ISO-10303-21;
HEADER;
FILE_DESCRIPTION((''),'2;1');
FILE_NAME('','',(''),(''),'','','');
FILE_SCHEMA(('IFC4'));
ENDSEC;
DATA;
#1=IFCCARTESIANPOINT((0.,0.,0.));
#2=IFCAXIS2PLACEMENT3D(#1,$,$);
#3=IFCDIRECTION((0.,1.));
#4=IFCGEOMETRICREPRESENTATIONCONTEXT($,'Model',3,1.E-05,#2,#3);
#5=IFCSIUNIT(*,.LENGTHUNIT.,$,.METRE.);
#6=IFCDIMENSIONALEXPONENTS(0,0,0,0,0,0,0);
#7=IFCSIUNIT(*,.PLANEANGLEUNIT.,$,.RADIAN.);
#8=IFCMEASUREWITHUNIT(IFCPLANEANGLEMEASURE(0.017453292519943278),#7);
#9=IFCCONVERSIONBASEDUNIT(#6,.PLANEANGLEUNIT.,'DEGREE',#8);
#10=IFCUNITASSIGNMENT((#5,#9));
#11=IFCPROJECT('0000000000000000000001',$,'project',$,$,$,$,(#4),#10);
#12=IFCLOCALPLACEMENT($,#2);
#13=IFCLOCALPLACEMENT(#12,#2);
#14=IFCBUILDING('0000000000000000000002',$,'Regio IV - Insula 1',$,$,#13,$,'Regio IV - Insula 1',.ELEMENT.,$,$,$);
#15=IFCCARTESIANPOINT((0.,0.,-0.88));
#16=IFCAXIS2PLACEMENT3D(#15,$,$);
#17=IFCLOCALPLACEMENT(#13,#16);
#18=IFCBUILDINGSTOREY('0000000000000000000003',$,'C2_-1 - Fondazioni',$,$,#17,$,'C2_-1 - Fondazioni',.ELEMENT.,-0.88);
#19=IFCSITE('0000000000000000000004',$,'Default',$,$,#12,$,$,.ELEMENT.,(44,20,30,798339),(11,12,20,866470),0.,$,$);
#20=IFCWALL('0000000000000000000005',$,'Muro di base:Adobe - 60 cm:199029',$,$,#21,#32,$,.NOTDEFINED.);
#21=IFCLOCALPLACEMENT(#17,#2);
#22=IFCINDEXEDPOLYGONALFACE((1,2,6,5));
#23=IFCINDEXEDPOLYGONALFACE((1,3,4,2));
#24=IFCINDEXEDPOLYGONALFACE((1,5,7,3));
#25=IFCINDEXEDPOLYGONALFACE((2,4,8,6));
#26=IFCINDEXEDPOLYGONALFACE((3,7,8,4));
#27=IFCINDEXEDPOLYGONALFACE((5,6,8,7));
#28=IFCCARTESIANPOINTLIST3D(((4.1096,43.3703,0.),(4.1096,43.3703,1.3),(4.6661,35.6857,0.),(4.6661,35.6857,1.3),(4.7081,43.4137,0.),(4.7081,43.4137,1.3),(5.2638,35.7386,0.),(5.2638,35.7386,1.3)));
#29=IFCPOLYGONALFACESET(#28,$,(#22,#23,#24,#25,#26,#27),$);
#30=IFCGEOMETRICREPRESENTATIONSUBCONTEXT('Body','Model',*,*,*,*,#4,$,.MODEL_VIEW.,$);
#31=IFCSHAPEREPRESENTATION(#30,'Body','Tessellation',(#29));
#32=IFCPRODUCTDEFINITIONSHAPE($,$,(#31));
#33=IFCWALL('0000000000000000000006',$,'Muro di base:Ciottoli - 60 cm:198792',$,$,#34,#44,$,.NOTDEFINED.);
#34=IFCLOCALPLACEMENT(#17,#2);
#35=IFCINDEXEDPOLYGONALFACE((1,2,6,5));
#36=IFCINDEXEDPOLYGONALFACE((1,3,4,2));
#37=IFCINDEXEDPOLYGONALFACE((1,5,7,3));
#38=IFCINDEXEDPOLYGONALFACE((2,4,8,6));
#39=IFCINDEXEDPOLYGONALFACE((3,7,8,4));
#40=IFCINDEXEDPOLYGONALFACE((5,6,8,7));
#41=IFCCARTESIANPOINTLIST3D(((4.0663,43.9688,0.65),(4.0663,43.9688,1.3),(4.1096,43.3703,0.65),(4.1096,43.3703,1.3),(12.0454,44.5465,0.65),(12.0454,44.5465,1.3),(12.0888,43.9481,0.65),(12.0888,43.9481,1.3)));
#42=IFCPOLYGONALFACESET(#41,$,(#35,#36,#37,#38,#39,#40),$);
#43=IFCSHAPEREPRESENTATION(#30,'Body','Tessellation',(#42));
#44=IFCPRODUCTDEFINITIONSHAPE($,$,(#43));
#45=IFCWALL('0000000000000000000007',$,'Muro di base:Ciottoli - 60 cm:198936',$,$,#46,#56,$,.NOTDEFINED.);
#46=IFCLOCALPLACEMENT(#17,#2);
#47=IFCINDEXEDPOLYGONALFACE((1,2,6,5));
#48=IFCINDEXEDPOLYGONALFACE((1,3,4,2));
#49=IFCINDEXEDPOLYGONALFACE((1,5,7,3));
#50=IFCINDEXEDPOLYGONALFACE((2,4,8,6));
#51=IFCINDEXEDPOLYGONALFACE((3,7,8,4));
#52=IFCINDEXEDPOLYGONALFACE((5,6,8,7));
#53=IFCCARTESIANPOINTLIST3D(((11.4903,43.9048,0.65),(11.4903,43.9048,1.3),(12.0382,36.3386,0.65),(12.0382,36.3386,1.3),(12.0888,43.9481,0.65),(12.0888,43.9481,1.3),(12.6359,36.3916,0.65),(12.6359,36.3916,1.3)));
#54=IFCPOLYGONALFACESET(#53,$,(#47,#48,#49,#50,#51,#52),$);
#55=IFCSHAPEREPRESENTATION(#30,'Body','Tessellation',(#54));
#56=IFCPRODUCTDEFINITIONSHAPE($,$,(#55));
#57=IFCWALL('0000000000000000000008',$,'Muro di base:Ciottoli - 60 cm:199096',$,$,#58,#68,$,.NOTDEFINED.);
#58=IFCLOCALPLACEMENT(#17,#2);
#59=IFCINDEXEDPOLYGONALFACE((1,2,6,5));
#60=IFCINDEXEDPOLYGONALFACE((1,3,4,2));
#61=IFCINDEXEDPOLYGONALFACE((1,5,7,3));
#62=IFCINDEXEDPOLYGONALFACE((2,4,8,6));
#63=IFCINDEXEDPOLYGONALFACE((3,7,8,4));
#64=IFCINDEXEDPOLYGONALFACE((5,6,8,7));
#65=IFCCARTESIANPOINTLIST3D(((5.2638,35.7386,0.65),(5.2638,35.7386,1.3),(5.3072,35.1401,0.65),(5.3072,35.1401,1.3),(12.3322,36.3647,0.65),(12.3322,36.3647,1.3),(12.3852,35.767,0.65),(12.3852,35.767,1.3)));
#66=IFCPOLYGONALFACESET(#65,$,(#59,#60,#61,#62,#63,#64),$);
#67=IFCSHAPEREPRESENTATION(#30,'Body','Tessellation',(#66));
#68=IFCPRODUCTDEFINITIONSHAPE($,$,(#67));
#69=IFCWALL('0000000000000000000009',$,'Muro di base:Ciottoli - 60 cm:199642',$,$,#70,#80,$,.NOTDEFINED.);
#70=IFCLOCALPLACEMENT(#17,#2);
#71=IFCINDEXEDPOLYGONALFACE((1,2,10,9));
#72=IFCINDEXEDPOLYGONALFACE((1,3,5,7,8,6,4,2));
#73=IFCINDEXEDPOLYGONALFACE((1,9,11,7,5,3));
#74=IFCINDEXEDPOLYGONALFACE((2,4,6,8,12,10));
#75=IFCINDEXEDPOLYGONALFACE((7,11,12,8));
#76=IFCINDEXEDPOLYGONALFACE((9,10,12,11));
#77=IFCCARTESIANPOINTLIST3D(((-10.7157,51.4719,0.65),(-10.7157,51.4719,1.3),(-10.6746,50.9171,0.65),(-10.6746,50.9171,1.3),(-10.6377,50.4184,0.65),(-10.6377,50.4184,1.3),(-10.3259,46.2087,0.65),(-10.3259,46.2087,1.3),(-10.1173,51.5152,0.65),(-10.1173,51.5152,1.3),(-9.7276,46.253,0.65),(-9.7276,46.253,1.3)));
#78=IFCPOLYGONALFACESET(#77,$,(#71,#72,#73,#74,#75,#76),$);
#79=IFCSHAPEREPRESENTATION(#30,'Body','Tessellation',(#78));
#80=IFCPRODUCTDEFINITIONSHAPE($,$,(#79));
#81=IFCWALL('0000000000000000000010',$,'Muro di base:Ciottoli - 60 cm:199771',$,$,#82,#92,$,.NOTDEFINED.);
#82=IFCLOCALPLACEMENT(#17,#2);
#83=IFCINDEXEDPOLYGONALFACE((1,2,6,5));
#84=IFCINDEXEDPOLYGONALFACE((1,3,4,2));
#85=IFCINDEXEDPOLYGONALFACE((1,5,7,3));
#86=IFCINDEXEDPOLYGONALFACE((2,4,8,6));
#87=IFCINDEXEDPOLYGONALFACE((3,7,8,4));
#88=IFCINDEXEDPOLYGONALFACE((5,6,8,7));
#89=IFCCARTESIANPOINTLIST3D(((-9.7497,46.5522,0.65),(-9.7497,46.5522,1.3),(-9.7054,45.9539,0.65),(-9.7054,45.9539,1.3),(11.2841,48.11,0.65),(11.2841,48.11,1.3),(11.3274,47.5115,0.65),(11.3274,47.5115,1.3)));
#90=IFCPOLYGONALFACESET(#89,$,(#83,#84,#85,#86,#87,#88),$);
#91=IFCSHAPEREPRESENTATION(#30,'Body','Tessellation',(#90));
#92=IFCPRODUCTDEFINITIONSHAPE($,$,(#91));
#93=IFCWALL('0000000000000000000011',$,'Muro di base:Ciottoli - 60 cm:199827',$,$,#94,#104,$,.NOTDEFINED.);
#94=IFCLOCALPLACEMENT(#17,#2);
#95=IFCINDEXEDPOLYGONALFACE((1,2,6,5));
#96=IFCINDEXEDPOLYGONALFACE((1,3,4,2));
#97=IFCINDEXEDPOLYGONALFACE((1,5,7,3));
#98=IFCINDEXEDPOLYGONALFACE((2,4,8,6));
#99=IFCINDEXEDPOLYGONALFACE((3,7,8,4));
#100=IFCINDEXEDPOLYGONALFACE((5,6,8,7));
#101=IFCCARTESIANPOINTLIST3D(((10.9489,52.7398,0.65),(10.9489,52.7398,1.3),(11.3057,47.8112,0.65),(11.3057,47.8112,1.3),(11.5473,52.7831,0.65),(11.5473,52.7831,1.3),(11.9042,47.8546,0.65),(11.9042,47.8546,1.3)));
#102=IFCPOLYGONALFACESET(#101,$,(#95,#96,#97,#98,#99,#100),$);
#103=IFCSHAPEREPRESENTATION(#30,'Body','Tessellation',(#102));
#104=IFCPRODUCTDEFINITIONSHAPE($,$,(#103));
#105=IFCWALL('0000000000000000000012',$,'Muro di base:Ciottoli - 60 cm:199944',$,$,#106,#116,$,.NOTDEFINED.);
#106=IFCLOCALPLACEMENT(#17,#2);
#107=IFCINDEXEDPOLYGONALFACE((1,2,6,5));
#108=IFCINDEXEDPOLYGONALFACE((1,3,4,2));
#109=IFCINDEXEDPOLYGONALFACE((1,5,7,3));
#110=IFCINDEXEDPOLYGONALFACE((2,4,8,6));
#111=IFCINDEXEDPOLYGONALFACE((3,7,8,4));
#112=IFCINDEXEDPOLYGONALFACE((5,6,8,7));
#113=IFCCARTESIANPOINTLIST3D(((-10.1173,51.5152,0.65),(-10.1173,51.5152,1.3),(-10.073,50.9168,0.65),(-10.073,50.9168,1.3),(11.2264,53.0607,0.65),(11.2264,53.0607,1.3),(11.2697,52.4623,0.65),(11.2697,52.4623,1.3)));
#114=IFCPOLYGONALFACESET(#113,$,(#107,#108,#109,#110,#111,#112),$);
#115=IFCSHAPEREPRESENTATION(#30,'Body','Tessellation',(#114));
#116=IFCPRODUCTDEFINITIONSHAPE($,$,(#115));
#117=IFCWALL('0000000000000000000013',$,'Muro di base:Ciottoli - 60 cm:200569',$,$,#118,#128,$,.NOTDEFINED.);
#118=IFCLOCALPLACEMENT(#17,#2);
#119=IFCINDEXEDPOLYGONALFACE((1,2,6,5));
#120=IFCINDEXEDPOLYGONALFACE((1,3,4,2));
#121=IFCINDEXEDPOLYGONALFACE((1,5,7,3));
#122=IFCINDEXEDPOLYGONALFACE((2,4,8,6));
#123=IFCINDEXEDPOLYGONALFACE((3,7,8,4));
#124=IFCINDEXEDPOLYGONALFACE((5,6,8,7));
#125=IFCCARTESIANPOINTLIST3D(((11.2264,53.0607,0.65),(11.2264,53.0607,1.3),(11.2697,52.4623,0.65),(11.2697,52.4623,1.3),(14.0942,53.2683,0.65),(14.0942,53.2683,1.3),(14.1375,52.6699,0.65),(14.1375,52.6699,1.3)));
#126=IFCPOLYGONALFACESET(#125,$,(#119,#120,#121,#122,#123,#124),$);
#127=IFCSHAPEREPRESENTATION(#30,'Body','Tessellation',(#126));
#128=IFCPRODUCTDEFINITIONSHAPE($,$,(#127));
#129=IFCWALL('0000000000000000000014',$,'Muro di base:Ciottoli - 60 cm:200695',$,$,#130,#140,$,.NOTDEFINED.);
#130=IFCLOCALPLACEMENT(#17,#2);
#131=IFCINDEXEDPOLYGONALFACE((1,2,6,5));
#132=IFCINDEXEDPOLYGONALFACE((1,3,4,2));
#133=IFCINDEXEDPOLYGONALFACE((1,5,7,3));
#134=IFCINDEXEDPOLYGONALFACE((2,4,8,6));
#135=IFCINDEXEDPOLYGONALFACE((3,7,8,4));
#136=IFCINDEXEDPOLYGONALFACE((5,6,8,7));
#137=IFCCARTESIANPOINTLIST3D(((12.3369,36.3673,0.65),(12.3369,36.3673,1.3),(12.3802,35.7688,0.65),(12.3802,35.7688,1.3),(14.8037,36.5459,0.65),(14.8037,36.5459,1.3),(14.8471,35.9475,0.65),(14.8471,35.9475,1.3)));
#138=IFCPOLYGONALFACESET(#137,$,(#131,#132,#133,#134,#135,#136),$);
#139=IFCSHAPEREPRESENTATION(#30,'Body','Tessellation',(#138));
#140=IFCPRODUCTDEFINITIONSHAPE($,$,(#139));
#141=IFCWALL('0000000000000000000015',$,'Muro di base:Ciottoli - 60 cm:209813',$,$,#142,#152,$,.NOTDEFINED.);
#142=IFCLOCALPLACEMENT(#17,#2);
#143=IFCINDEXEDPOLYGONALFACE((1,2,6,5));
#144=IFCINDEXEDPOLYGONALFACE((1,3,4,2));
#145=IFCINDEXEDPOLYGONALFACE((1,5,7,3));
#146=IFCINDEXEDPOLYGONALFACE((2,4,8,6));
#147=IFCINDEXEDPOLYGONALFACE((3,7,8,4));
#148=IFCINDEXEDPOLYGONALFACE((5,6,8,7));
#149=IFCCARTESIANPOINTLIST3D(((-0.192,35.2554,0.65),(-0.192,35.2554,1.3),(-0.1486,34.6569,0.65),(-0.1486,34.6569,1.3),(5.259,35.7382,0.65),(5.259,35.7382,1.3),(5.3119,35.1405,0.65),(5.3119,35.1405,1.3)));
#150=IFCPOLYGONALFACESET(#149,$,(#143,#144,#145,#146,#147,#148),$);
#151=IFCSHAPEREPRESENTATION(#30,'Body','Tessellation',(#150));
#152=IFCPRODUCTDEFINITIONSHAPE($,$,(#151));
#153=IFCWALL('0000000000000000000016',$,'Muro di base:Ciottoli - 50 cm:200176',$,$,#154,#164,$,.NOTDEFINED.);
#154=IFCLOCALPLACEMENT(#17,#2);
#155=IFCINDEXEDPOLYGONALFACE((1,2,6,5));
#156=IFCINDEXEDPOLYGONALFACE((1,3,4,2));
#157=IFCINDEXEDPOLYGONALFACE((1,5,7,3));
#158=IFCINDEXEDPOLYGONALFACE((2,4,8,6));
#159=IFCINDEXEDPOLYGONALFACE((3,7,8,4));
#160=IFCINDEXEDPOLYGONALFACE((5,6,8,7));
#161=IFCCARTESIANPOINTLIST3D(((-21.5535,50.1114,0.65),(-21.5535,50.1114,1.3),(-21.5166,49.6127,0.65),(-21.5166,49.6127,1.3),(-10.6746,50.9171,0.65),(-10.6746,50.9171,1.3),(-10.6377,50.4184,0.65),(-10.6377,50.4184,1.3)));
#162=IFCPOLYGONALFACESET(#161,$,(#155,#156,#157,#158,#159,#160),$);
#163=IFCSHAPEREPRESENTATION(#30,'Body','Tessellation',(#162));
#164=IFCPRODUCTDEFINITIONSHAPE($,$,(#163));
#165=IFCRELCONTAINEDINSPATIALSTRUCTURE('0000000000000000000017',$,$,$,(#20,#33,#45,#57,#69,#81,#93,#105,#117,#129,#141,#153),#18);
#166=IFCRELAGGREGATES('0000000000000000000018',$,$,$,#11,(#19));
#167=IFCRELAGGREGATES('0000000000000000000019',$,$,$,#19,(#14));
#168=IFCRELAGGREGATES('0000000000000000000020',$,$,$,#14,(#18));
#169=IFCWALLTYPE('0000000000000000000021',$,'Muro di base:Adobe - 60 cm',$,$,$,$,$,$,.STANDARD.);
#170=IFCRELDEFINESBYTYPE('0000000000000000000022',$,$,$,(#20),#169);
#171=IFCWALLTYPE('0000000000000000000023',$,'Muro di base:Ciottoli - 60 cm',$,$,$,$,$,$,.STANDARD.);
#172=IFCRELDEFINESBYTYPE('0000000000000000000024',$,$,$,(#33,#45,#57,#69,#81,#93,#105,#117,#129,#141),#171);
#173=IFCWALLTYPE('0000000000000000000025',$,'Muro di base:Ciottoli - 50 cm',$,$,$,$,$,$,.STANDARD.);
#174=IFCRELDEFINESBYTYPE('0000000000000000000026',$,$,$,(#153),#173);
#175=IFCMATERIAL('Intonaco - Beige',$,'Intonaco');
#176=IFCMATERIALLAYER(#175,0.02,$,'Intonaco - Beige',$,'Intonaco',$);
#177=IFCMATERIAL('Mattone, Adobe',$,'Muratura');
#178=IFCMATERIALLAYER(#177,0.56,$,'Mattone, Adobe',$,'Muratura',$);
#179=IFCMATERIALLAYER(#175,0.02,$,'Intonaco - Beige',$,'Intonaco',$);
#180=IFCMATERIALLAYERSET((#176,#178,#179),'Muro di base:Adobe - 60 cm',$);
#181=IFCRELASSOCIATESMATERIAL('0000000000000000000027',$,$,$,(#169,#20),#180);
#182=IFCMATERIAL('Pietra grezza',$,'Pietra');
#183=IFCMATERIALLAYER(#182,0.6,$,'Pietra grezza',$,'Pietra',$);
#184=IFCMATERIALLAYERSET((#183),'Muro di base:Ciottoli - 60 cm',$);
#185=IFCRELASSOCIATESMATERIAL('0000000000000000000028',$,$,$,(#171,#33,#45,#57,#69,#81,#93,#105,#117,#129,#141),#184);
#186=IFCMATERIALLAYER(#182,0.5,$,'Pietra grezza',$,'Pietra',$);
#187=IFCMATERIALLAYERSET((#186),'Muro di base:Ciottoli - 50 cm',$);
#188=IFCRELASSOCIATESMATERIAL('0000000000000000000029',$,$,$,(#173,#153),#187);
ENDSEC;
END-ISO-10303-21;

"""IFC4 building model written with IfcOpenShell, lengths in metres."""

from ifc_helpers import new_model, entity, si_unit, converted_unit, direction, frame, frame_2d, origin, place, context, subcontext, project, spatial, polyline, rectangle, outline, extrude, material, layer, layer_set, layer_usage, type_object, element, save


model = new_model("IFC4")

# Units and contexts
model_context = context("Model", 3, precision=1e-05, world=origin(), true_north=direction((0.0, 1.0)))
body_context = subcontext(model_context, "Body", "Model", "MODEL_VIEW")
ifc_project = project(units=[si_unit("LENGTHUNIT", "METRE"), converted_unit("PLANEANGLEUNIT", "DEGREE", entity("IfcPlaneAngleMeasure", 0.017453292519943278), si_unit("PLANEANGLEUNIT", "RADIAN"), dimensions=[0, 0, 0, 0, 0, 0, 0])], contexts=[model_context])

# Site, building, storey
site_placement = place(None, origin())
site = spatial("IfcSite", under=ifc_project, at=site_placement, Name="Default", CompositionType="ELEMENT", RefLatitude=(44, 20, 30, 798339), RefLongitude=(11, 12, 20, 866470), RefElevation=0.0)
building_placement = place(site_placement, origin())
building = spatial("IfcBuilding", under=site, at=building_placement, Name="Regio IV - Insula 1", LongName="Regio IV - Insula 1", CompositionType="ELEMENT")
storey_placement = place(building_placement, frame((0.0, 0.0, -0.88)))
storey = spatial("IfcBuildingStorey", under=building, at=storey_placement, Name="C2_-1 - Fondazioni", LongName="C2_-1 - Fondazioni", CompositionType="ELEMENT", Elevation=-0.88)

# Walls
ifc_material_1 = material(Name="Intonaco - Beige", Category="Intonaco")
ifc_layer_1 = layer(ifc_material_1, 0.02, Name="Intonaco - Beige", Category="Intonaco")
ifc_material_2 = material(Name="Mattone, Adobe", Category="Muratura")
ifc_layer_2 = layer(ifc_material_2, 0.56, Name="Mattone, Adobe", Category="Muratura")
ifc_layer_3 = layer(ifc_material_1, 0.02, Name="Intonaco - Beige", Category="Intonaco")
ifc_layer_set_1 = layer_set([ifc_layer_1, ifc_layer_2, ifc_layer_3], Name="Muro di base:Adobe - 60 cm")
ifc_layer_usage_1 = layer_usage(ifc_layer_set_1, "AXIS2", "NEGATIVE", 0.3)
wall_type_1 = type_object("IfcWallType", Name="Muro di base:Adobe - 60 cm", PredefinedType="STANDARD", material=ifc_layer_set_1)
wall_1_placement = place(storey_placement, frame((4.4089, 43.392, 0.0), z_axis=(0.0, 0.0, 1.0), x_axis=(0.07222, -0.997389, 0.0)))
element("IfcWall", 1, at=wall_1_placement, inside=storey, type_object=wall_type_1, material=ifc_layer_usage_1, Name="Muro di base:Adobe - 60 cm:199029", PredefinedType="NOTDEFINED", context=body_context, shape_type="SweptSolid", body=[
    extrude(outline(polyline([(7.7048, -0.3), (7.6951, 0.3), (0.0, 0.3), (0.0, -0.3), (7.7048, -0.3)])), origin(), (0.0, 0.0, 1.0), 1.3),
])
ifc_material_3 = material(Name="Pietra grezza", Category="Pietra")
ifc_layer_4 = layer(ifc_material_3, 0.6, Name="Pietra grezza", Category="Pietra")
ifc_layer_set_2 = layer_set([ifc_layer_4], Name="Muro di base:Ciottoli - 60 cm")
ifc_layer_usage_2 = layer_usage(ifc_layer_set_2, "AXIS2", "NEGATIVE", 0.3)
wall_type_2 = type_object("IfcWallType", Name="Muro di base:Ciottoli - 60 cm", PredefinedType="STANDARD", material=ifc_layer_set_2)
wall_2_placement = place(storey_placement, frame((4.088, 43.6695, 0.65), z_axis=(0.0, 0.0, 1.0), x_axis=(0.997389, 0.07222, 0.0)))
element("IfcWall", 2, at=wall_2_placement, inside=storey, type_object=wall_type_2, material=ifc_layer_usage_2, Name="Muro di base:Ciottoli - 60 cm:198792", PredefinedType="NOTDEFINED", context=body_context, shape_type="SweptSolid", body=[
    extrude(rectangle(XDim=8.0, YDim=0.6, at=frame_2d((4.0, 0.0), x_axis=(-1.0, 0.0))), origin(), (0.0, 0.0, 1.0), 0.65),
])
ifc_layer_usage_3 = layer_usage(ifc_layer_set_2, "AXIS2", "NEGATIVE", 0.3)
wall_3_placement = place(storey_placement, frame((11.7895, 43.9264, 0.65), z_axis=(0.0, 0.0, 1.0), x_axis=(0.07222, -0.997389, 0.0)))
element("IfcWall", 3, at=wall_3_placement, inside=storey, type_object=wall_type_2, material=ifc_layer_usage_3, Name="Muro di base:Ciottoli - 60 cm:198936", PredefinedType="NOTDEFINED", context=body_context, shape_type="SweptSolid", body=[
    extrude(outline(polyline([(7.5859, -0.3), (7.5763, 0.3), (0.0, 0.3), (0.0, -0.3), (7.5859, -0.3)])), origin(), (0.0, 0.0, 1.0), 0.65),
])
ifc_layer_usage_4 = layer_usage(ifc_layer_set_2, "AXIS2", "NEGATIVE", 0.3)
wall_4_placement = place(storey_placement, frame((5.2807, 35.4389, 0.65), z_axis=(0.0, 0.0, 1.0), x_axis=(0.996101, 0.088225, 0.0)))
element("IfcWall", 4, at=wall_4_placement, inside=storey, type_object=wall_type_2, material=ifc_layer_usage_4, Name="Muro di base:Ciottoli - 60 cm:199096", PredefinedType="NOTDEFINED", context=body_context, shape_type="SweptSolid", body=[
    extrude(outline(polyline([(7.1057, -0.3), (7.1057, 0.3), (0.0096, 0.3), (0.0, -0.3), (7.1057, -0.3)])), origin(), (0.0, 0.0, 1.0), 0.65),
])
ifc_layer_usage_5 = layer_usage(ifc_layer_set_2, "AXIS2", "NEGATIVE", 0.3)
wall_5_placement = place(storey_placement, frame((-10.4165, 51.494, 0.65), z_axis=(0.0, 0.0, 1.0), x_axis=(0.073856, -0.997269, 0.0)))
element("IfcWall", 5, at=wall_5_placement, inside=storey, type_object=wall_type_2, material=ifc_layer_usage_5, Name="Muro di base:Ciottoli - 60 cm:199642", PredefinedType="NOTDEFINED", context=body_context, shape_type="SweptSolid", body=[
    extrude(outline(polyline([(5.2776, -0.3), (5.2776, 0.3), (0.001, 0.3), (0.0, -0.3), (0.5563, -0.3), (1.0563, -0.3), (5.2776, -0.3)])), origin(), (0.0, 0.0, 1.0), 0.65),
])
ifc_layer_usage_6 = layer_usage(ifc_layer_set_2, "AXIS2", "NEGATIVE", 0.3)
wall_6_placement = place(storey_placement, frame((-9.7276, 46.253, 0.65), z_axis=(0.0, 0.0, 1.0), x_axis=(0.997269, 0.073857, 0.0)))
element("IfcWall", 6, at=wall_6_placement, inside=storey, type_object=wall_type_2, material=ifc_layer_usage_6, Name="Muro di base:Ciottoli - 60 cm:199771", PredefinedType="NOTDEFINED", context=body_context, shape_type="SweptSolid", body=[
    extrude(outline(polyline([(21.0905, -0.3), (21.0914, 0.3), (0.0, 0.3), (0.0, -0.3), (21.0905, -0.3)])), origin(), (0.0, 0.0, 1.0), 0.65),
])
ifc_layer_usage_7 = layer_usage(ifc_layer_set_2, "AXIS2", "NEGATIVE", 0.3)
wall_7_placement = place(storey_placement, frame((11.6049, 47.8329, 0.65), z_axis=(0.0, 0.0, 1.0), x_axis=(-0.07222, 0.997389, 0.0)))
element("IfcWall", 7, at=wall_7_placement, inside=storey, type_object=wall_type_2, material=ifc_layer_usage_7, Name="Muro di base:Ciottoli - 60 cm:199827", PredefinedType="NOTDEFINED", context=body_context, shape_type="SweptSolid", body=[
    extrude(rectangle(XDim=4.9415, YDim=0.6, at=frame_2d((2.4707, 0.0), x_axis=(-1.0, 0.0))), origin(), (0.0, 0.0, 1.0), 0.65),
])
ifc_layer_usage_8 = layer_usage(ifc_layer_set_2, "AXIS2", "NEGATIVE", 0.3)
wall_8_placement = place(storey_placement, frame((11.2481, 52.7615, 0.65), z_axis=(0.0, 0.0, 1.0), x_axis=(-0.997389, -0.07222, 0.0)))
element("IfcWall", 8, at=wall_8_placement, inside=storey, type_object=wall_type_2, material=ifc_layer_usage_8, Name="Muro di base:Ciottoli - 60 cm:199944", PredefinedType="NOTDEFINED", context=body_context, shape_type="SweptSolid", body=[
    extrude(outline(polyline([(21.3996, -0.3), (21.3986, 0.3), (0.0, 0.3), (0.0, -0.3), (21.3996, -0.3)])), origin(), (0.0, 0.0, 1.0), 0.65),
])
ifc_layer_usage_9 = layer_usage(ifc_layer_set_2, "AXIS2", "NEGATIVE", 0.3)
wall_9_placement = place(storey_placement, frame((11.2481, 52.7615, 0.65), z_axis=(0.0, 0.0, 1.0), x_axis=(0.997389, 0.07222, 0.0)))
element("IfcWall", 9, at=wall_9_placement, inside=storey, type_object=wall_type_2, material=ifc_layer_usage_9, Name="Muro di base:Ciottoli - 60 cm:200569", PredefinedType="NOTDEFINED", context=body_context, shape_type="SweptSolid", body=[
    extrude(rectangle(XDim=2.8753, YDim=0.6, at=frame_2d((1.4376, 0.0), x_axis=(-1.0, 0.0))), origin(), (0.0, 0.0, 1.0), 0.65),
])
ifc_layer_usage_10 = layer_usage(ifc_layer_set_2, "AXIS2", "NEGATIVE", 0.3)
wall_10_placement = place(storey_placement, frame((14.8254, 36.2467, 0.65), z_axis=(0.0, 0.0, 1.0), x_axis=(-0.997389, -0.07222, 0.0)))
element("IfcWall", 10, at=wall_10_placement, inside=storey, type_object=wall_type_2, material=ifc_layer_usage_10, Name="Muro di base:Ciottoli - 60 cm:200695", PredefinedType="NOTDEFINED", context=body_context, shape_type="SweptSolid", body=[
    extrude(rectangle(XDim=2.4733, YDim=0.6, at=frame_2d((1.2367, 0.0), x_axis=(-1.0, 0.0))), origin(), (0.0, 0.0, 1.0), 0.65),
])
ifc_layer_usage_11 = layer_usage(ifc_layer_set_2, "AXIS2", "NEGATIVE", 0.3)
wall_11_placement = place(storey_placement, frame((-0.1751, 34.9557, 0.65), z_axis=(0.0, 0.0, 1.0), x_axis=(0.996101, 0.088225, 0.0)))
element("IfcWall", 11, at=wall_11_placement, inside=storey, type_object=wall_type_2, material=ifc_layer_usage_11, Name="Muro di base:Ciottoli - 60 cm:209813", PredefinedType="NOTDEFINED", context=body_context, shape_type="SweptSolid", body=[
    extrude(outline(polyline([(5.4819, -0.3), (5.4819, 0.3), (0.0096, 0.3), (0.0, -0.3), (5.4819, -0.3)])), origin(), (0.0, 0.0, 1.0), 0.65),
])
ifc_layer_5 = layer(ifc_material_3, 0.5, Name="Pietra grezza", Category="Pietra")
ifc_layer_set_3 = layer_set([ifc_layer_5], Name="Muro di base:Ciottoli - 50 cm")
ifc_layer_usage_12 = layer_usage(ifc_layer_set_3, "AXIS2", "NEGATIVE", 0.25)
wall_type_3 = type_object("IfcWallType", Name="Muro di base:Ciottoli - 50 cm", PredefinedType="STANDARD", material=ifc_layer_set_3)
wall_12_placement = place(storey_placement, frame((-21.5351, 49.8621, 0.65), z_axis=(0.0, 0.0, 1.0), x_axis=(0.997269, 0.073857, 0.0)))
element("IfcWall", 12, at=wall_12_placement, inside=storey, type_object=wall_type_3, material=ifc_layer_usage_12, Name="Muro di base:Ciottoli - 50 cm:200176", PredefinedType="NOTDEFINED", context=body_context, shape_type="SweptSolid", body=[
    extrude(rectangle(XDim=10.9087, YDim=0.5, at=frame_2d((5.4543, 0.0), x_axis=(-1.0, 0.0))), origin(), (0.0, 0.0, 1.0), 0.65),
])

save(model, "model.ifc")
